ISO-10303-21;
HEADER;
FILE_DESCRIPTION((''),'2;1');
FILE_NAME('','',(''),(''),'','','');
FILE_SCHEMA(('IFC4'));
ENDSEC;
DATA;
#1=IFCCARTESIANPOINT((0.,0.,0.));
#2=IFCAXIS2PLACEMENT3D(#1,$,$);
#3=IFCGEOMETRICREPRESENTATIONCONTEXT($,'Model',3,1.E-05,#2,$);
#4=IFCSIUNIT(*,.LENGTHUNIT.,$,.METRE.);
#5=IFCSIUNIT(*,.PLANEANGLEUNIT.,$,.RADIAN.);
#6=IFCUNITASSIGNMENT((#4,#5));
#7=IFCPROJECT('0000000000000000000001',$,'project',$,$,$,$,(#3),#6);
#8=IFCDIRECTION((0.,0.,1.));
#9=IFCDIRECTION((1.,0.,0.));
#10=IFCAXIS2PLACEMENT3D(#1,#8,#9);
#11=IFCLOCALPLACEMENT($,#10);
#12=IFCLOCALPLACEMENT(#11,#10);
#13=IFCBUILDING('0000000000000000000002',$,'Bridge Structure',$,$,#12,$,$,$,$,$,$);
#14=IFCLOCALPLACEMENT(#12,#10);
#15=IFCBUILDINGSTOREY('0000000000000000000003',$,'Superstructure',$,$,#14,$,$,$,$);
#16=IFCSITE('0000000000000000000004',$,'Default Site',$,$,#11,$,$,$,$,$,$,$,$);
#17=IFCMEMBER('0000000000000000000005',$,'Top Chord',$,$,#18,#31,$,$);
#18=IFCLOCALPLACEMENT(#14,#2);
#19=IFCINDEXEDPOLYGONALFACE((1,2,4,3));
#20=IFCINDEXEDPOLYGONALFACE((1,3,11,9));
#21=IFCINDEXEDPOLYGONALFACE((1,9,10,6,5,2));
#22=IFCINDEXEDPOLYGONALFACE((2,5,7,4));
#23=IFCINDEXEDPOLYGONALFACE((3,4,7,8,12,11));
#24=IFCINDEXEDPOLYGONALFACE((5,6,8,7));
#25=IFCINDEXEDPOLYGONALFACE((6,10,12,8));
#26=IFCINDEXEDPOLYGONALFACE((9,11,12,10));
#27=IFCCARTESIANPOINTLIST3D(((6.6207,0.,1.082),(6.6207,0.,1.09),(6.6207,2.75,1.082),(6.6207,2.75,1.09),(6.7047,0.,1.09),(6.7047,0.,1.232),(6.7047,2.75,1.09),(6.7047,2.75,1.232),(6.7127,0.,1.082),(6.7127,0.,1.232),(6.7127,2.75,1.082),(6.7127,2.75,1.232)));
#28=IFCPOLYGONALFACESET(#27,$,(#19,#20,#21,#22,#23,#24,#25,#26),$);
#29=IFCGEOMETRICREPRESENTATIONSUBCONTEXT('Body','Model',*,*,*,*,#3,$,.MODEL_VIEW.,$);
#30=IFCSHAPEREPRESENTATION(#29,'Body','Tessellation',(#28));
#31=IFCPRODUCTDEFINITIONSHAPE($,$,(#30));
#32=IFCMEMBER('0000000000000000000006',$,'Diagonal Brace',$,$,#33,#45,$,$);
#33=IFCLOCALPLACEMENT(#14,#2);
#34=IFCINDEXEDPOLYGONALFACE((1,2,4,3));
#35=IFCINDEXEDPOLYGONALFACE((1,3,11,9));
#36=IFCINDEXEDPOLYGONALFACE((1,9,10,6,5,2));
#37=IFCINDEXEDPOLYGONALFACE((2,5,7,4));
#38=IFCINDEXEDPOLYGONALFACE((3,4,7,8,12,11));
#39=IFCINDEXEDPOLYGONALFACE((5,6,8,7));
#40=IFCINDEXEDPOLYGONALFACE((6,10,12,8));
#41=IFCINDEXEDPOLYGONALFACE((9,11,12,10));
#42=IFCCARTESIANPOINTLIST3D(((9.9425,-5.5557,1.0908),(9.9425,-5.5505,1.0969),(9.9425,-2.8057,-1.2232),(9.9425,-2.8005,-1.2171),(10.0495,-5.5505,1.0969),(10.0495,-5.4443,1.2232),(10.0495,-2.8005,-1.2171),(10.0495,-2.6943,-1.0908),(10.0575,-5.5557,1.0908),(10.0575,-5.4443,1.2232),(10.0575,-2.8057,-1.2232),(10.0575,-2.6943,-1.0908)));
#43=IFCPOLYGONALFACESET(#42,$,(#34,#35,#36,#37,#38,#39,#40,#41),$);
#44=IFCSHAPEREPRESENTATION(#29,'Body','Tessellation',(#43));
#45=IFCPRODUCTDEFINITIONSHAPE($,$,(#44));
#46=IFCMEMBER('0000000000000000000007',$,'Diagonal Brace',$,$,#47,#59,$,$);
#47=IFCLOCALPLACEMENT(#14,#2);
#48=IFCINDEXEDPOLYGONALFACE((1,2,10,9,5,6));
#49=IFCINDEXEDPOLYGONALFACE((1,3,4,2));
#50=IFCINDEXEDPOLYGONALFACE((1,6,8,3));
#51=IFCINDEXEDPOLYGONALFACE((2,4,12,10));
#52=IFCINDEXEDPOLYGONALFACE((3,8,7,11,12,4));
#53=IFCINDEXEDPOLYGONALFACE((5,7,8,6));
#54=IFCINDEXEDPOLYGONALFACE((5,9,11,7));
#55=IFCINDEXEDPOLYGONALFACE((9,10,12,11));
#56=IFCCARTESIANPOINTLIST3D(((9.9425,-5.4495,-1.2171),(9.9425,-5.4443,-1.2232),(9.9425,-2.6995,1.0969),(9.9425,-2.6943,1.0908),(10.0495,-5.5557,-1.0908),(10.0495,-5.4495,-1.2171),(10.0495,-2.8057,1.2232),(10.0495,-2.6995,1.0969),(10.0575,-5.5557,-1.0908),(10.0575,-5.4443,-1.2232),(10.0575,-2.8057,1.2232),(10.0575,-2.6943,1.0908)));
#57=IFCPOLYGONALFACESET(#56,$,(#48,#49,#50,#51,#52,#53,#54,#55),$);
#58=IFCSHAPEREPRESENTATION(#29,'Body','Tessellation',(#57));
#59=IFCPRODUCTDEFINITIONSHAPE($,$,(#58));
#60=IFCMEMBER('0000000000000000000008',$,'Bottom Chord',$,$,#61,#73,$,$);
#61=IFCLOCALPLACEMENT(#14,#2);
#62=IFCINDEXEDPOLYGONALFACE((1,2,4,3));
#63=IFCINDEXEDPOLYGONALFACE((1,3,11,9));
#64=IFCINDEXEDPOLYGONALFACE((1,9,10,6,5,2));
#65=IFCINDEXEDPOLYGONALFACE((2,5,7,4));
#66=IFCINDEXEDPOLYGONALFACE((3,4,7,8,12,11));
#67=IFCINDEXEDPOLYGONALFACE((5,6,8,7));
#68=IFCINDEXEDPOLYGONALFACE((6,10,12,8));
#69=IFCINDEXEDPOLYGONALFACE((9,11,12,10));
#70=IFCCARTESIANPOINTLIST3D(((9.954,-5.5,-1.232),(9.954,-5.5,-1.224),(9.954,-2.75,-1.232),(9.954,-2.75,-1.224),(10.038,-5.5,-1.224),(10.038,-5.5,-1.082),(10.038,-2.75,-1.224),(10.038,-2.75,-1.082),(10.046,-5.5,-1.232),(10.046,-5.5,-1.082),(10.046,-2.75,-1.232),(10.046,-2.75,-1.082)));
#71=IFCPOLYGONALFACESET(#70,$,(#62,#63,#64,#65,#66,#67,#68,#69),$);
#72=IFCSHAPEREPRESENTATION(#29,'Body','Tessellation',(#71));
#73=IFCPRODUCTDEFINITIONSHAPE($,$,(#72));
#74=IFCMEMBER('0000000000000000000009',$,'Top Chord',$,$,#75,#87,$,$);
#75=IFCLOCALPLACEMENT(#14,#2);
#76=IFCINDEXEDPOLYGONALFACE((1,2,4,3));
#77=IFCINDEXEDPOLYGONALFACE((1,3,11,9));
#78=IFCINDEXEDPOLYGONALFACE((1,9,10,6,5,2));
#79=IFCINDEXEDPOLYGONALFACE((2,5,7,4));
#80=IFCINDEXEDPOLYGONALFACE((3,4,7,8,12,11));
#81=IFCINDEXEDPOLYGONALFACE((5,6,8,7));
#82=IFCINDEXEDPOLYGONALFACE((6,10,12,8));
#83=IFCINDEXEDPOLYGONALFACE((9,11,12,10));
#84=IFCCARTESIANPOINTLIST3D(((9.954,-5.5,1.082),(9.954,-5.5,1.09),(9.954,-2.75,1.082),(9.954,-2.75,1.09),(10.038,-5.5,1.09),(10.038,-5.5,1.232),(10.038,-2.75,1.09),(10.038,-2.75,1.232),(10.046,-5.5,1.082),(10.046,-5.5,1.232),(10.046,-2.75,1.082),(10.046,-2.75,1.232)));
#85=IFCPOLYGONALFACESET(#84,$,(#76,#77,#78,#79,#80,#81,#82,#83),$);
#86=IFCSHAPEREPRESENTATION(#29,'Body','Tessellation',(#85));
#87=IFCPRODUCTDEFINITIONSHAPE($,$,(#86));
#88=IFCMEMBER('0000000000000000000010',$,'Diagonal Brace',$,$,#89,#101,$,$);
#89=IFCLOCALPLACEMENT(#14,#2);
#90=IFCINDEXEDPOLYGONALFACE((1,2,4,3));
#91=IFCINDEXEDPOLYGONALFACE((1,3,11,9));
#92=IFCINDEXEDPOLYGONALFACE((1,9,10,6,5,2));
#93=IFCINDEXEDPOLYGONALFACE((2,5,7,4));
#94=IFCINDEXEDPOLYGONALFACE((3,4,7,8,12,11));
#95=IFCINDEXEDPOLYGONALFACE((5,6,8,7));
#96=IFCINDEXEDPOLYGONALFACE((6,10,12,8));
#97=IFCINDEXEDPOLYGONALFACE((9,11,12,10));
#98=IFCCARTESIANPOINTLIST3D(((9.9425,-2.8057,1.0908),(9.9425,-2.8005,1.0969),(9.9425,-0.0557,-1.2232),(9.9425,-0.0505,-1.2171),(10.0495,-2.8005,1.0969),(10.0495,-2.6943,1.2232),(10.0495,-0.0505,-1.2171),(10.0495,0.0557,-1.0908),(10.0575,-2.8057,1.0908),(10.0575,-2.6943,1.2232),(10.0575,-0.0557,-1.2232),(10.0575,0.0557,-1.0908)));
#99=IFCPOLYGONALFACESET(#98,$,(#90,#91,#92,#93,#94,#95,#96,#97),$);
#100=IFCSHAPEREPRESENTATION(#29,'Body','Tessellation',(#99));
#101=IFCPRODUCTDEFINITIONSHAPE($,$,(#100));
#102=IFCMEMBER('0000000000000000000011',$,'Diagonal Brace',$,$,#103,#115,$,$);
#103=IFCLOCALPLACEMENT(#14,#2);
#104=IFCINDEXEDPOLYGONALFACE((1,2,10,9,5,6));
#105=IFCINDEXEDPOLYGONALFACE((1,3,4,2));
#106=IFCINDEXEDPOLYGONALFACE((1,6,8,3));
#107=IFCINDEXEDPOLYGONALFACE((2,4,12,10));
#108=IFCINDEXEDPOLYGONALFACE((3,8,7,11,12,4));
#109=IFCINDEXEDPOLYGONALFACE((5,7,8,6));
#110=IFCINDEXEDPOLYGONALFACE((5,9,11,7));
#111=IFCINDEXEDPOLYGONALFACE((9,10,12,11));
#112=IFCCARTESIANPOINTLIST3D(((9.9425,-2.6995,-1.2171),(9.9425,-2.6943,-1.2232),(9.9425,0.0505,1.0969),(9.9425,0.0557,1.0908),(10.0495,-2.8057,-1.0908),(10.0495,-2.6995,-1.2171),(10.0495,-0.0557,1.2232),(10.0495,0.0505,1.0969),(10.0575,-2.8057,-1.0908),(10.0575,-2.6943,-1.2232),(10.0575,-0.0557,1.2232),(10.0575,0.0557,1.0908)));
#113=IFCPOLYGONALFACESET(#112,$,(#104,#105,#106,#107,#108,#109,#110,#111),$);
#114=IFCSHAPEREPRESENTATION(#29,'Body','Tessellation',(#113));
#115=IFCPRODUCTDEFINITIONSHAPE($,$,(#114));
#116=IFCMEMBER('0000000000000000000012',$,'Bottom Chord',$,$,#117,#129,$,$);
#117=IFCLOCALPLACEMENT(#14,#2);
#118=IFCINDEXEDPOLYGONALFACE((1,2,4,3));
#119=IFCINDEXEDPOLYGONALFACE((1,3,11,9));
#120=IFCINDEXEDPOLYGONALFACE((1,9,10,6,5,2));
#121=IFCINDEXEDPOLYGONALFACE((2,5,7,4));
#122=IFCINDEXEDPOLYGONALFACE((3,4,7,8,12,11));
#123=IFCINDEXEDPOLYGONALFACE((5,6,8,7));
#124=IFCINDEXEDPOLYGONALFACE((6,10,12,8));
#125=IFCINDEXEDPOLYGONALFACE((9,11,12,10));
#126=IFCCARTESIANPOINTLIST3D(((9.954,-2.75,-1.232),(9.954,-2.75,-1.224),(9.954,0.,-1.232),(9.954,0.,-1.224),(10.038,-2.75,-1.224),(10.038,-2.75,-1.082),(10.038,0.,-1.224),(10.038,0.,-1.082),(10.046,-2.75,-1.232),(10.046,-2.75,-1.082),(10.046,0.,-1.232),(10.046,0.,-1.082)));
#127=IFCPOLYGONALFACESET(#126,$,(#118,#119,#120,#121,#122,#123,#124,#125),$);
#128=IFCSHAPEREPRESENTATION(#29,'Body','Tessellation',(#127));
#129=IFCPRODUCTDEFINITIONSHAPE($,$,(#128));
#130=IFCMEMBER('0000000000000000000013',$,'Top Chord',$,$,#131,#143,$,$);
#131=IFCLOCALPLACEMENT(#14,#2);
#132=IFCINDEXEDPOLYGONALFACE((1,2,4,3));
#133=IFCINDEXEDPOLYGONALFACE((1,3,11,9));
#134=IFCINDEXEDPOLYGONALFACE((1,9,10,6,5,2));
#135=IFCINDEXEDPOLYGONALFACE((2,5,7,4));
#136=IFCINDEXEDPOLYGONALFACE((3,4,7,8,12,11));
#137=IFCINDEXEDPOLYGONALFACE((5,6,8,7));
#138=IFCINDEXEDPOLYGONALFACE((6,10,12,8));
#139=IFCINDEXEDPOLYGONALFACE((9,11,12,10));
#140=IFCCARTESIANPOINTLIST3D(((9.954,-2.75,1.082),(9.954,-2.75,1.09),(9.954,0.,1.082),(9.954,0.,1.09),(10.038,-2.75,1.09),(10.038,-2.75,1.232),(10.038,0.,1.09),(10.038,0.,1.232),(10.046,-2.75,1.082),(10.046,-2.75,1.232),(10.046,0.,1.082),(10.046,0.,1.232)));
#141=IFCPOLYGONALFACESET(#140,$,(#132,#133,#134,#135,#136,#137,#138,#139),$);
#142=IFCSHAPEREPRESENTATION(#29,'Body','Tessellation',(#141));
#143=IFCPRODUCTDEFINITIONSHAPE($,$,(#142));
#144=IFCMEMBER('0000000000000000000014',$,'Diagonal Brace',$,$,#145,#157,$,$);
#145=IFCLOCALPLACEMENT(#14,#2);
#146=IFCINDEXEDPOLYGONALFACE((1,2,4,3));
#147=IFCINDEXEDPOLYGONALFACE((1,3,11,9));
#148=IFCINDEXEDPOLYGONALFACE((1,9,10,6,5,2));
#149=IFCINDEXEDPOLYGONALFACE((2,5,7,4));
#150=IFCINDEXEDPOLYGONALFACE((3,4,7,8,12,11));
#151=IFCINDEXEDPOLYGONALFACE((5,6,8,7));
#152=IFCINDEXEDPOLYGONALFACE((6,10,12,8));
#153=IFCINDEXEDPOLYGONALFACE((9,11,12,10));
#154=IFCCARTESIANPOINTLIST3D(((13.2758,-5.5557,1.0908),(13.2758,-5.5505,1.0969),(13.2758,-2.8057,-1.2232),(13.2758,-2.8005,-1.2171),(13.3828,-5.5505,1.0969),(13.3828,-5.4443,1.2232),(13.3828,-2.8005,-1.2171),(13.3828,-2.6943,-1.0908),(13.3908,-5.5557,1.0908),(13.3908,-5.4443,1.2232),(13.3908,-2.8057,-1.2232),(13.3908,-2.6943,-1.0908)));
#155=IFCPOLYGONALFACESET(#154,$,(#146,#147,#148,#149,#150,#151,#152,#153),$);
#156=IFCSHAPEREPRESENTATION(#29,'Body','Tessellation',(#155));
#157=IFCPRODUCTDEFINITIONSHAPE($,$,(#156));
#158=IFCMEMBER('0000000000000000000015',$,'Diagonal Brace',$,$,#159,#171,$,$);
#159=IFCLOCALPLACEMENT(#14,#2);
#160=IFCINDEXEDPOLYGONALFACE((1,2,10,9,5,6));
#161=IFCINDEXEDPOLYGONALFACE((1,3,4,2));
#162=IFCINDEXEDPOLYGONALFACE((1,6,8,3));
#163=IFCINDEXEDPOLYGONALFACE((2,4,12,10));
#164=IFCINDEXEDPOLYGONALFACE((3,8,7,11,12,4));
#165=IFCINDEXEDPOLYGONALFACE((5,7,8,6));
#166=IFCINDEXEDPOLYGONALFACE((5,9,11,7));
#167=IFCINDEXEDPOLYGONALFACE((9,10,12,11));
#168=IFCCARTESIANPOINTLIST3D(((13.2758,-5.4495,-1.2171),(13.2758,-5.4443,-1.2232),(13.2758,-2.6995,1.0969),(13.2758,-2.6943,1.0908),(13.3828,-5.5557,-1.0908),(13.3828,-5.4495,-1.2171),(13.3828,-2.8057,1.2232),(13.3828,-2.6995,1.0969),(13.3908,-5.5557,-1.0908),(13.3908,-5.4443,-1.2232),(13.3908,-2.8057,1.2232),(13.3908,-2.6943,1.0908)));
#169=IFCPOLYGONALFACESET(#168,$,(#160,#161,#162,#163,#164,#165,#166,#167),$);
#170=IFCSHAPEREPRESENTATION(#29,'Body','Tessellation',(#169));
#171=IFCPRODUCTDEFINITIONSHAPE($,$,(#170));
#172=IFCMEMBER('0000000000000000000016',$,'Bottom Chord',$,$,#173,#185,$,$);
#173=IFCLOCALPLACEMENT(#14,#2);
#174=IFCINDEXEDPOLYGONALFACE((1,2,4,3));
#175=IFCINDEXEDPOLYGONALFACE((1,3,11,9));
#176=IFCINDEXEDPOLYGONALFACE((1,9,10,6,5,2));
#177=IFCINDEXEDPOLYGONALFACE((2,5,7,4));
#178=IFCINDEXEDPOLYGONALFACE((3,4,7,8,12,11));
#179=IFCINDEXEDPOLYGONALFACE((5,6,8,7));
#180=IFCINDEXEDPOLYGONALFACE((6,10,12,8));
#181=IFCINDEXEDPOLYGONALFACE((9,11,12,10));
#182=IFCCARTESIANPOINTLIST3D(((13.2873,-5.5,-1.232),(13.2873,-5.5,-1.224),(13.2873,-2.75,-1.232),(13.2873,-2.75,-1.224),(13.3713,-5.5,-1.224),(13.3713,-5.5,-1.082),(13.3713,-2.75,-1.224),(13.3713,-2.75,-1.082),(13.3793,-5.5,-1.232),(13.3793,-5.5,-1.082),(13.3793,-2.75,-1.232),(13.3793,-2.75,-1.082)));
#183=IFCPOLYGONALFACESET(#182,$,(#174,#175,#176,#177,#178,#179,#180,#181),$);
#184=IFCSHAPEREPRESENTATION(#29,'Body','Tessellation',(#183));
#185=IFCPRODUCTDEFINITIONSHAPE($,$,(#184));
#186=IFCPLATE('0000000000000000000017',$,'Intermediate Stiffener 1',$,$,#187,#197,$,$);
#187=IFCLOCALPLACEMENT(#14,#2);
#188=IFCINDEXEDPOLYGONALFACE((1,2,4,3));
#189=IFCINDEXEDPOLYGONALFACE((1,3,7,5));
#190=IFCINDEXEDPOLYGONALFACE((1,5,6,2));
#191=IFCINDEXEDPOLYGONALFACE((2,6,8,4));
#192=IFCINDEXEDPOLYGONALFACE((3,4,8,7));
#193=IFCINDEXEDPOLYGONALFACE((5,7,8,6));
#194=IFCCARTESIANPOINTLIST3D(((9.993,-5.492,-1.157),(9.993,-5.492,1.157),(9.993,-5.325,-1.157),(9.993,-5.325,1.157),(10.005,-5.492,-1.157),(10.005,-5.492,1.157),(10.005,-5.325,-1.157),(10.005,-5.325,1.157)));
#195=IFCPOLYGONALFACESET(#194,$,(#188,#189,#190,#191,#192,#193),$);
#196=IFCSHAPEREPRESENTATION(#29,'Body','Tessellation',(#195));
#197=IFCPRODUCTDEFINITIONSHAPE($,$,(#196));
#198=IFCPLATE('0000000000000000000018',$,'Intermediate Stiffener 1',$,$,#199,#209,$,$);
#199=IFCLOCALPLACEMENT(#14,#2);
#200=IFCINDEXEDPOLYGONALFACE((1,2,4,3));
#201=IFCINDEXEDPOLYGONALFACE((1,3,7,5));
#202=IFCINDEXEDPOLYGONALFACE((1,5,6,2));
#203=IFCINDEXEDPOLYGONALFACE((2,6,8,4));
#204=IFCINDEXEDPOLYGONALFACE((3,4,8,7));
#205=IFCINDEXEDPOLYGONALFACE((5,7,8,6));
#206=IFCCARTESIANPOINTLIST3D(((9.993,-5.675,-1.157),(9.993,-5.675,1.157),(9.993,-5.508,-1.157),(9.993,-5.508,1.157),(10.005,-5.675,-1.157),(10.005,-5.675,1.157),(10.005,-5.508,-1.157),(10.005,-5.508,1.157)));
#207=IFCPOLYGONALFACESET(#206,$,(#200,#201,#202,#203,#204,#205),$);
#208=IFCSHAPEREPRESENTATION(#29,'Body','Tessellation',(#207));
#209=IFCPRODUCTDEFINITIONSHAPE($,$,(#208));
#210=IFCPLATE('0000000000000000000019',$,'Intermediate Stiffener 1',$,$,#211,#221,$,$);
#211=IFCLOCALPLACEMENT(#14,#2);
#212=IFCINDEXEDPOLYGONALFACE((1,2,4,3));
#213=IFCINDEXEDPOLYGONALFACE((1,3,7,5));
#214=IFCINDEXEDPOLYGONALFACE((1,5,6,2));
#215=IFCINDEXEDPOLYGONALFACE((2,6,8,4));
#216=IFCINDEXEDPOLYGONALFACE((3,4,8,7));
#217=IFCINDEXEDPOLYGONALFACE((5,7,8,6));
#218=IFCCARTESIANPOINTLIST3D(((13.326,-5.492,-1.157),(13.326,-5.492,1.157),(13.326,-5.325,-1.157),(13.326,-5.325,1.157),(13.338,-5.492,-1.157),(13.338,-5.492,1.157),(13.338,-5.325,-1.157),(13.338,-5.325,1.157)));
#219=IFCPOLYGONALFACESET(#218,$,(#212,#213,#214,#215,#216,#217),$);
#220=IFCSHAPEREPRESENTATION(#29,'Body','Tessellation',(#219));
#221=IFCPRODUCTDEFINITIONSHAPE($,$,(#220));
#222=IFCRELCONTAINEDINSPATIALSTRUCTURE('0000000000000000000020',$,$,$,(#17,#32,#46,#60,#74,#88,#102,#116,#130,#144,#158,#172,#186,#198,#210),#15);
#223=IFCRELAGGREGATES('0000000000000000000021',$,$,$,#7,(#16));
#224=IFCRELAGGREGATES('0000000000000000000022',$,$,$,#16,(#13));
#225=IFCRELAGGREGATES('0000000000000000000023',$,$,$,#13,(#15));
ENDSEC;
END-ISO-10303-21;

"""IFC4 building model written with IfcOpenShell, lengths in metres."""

from ifc_helpers import new_model, si_unit, frame, origin, origin_with_axes, origin_2d_with_axis, place, context, subcontext, project, spatial, rectangle, l_section, extrude, element, save


model = new_model("IFC4")

# Units and contexts
model_context = context("Model", 3, precision=1e-05, world=origin())
body_context = subcontext(model_context, "Body", "Model", "MODEL_VIEW")
ifc_project = project(units=[si_unit("LENGTHUNIT", "METRE"), si_unit("PLANEANGLEUNIT", "RADIAN")], contexts=[model_context])

# Site, building, storey
site_placement = place(None, origin_with_axes())
site = spatial("IfcSite", under=ifc_project, at=site_placement, Name="Default Site")
building_placement = place(site_placement, origin_with_axes())
building = spatial("IfcBuilding", under=site, at=building_placement, Name="Bridge Structure")
storey_placement = place(building_placement, origin_with_axes())
storey = spatial("IfcBuildingStorey", under=building, at=storey_placement, Name="Superstructure")

# Members
member_1_placement = place(storey_placement, frame((6.6667, 0.0, 1.157), z_axis=(0.0, 1.0, 0.0), x_axis=(-1.0, 0.0, 0.0)))
element("IfcMember", 1, at=member_1_placement, inside=storey, Name="Top Chord", context=body_context, shape_type="SweptSolid", body=[
    extrude(l_section(Depth=0.15, Width=0.092, Thickness=0.008, at=origin_2d_with_axis()), origin_with_axes(), (0.0, 0.0, 1.0), 2.75),
])
for number, where, z_axis, x_axis, name in (
    (2, (10.0, -5.5, 1.157), (0.0, 0.765156, -0.643844), (-1.0, 0.0, 0.0), "Diagonal Brace"),
    (3, (10.0, -5.5, -1.157), (0.0, 0.765156, 0.643844), (-1.0, 0.0, 0.0), "Diagonal Brace"),
):
    element("IfcMember", number, at=place(storey_placement, frame(where, z_axis=z_axis, x_axis=x_axis)), inside=storey, Name=name, context=body_context, shape_type="SweptSolid", body=[
        extrude(l_section(Depth=0.173, Width=0.115, Thickness=0.008, at=origin_2d_with_axis()), origin_with_axes(), (0.0, 0.0, 1.0), 3.594),
    ])
for number, where, z_axis, x_axis, name in (
    (4, (10.0, -5.5, -1.157), (0.0, 1.0, 0.0), (-1.0, 0.0, 0.0), "Bottom Chord"),
    (5, (10.0, -5.5, 1.157), (0.0, 1.0, 0.0), (-1.0, 0.0, 0.0), "Top Chord"),
):
    element("IfcMember", number, at=place(storey_placement, frame(where, z_axis=z_axis, x_axis=x_axis)), inside=storey, Name=name, context=body_context, shape_type="SweptSolid", body=[
        extrude(l_section(Depth=0.15, Width=0.092, Thickness=0.008, at=origin_2d_with_axis()), origin_with_axes(), (0.0, 0.0, 1.0), 2.75),
    ])
for number, where, z_axis, x_axis, name in (
    (6, (10.0, -2.75, 1.157), (0.0, 0.765156, -0.643844), (-1.0, 0.0, 0.0), "Diagonal Brace"),
    (7, (10.0, -2.75, -1.157), (0.0, 0.765156, 0.643844), (-1.0, 0.0, 0.0), "Diagonal Brace"),
):
    element("IfcMember", number, at=place(storey_placement, frame(where, z_axis=z_axis, x_axis=x_axis)), inside=storey, Name=name, context=body_context, shape_type="SweptSolid", body=[
        extrude(l_section(Depth=0.173, Width=0.115, Thickness=0.008, at=origin_2d_with_axis()), origin_with_axes(), (0.0, 0.0, 1.0), 3.594),
    ])
for number, where, z_axis, x_axis, name in (
    (8, (10.0, -2.75, -1.157), (0.0, 1.0, 0.0), (-1.0, 0.0, 0.0), "Bottom Chord"),
    (9, (10.0, -2.75, 1.157), (0.0, 1.0, 0.0), (-1.0, 0.0, 0.0), "Top Chord"),
):
    element("IfcMember", number, at=place(storey_placement, frame(where, z_axis=z_axis, x_axis=x_axis)), inside=storey, Name=name, context=body_context, shape_type="SweptSolid", body=[
        extrude(l_section(Depth=0.15, Width=0.092, Thickness=0.008, at=origin_2d_with_axis()), origin_with_axes(), (0.0, 0.0, 1.0), 2.75),
    ])
for number, where, z_axis, x_axis, name in (
    (10, (13.3333, -5.5, 1.157), (0.0, 0.765156, -0.643844), (-1.0, 0.0, 0.0), "Diagonal Brace"),
    (11, (13.3333, -5.5, -1.157), (0.0, 0.765156, 0.643844), (-1.0, 0.0, 0.0), "Diagonal Brace"),
):
    element("IfcMember", number, at=place(storey_placement, frame(where, z_axis=z_axis, x_axis=x_axis)), inside=storey, Name=name, context=body_context, shape_type="SweptSolid", body=[
        extrude(l_section(Depth=0.173, Width=0.115, Thickness=0.008, at=origin_2d_with_axis()), origin_with_axes(), (0.0, 0.0, 1.0), 3.594),
    ])
member_2_placement = place(storey_placement, frame((13.3333, -5.5, -1.157), z_axis=(0.0, 1.0, 0.0), x_axis=(-1.0, 0.0, 0.0)))
element("IfcMember", 12, at=member_2_placement, inside=storey, Name="Bottom Chord", context=body_context, shape_type="SweptSolid", body=[
    extrude(l_section(Depth=0.15, Width=0.092, Thickness=0.008, at=origin_2d_with_axis()), origin_with_axes(), (0.0, 0.0, 1.0), 2.75),
])

# Plates
for number, where, z_axis, x_axis, name in (
    (13, (9.999, -5.4085, -1.157), (0.0, 0.0, 1.0), (1.0, 0.0, 0.0), "Intermediate Stiffener 1"),
    (14, (9.999, -5.5915, -1.157), (0.0, 0.0, 1.0), (1.0, 0.0, 0.0), "Intermediate Stiffener 1"),
    (15, (13.332, -5.4085, -1.157), (0.0, 0.0, 1.0), (1.0, 0.0, 0.0), "Intermediate Stiffener 1"),
):
    element("IfcPlate", number, at=place(storey_placement, frame(where, z_axis=z_axis, x_axis=x_axis)), inside=storey, Name=name, context=body_context, shape_type="SweptSolid", body=[
        extrude(rectangle(XDim=0.012, YDim=0.167, at=origin_2d_with_axis()), origin_with_axes(), (0.0, 0.0, 1.0), 2.314),
    ])

save(model, "model.ifc")
